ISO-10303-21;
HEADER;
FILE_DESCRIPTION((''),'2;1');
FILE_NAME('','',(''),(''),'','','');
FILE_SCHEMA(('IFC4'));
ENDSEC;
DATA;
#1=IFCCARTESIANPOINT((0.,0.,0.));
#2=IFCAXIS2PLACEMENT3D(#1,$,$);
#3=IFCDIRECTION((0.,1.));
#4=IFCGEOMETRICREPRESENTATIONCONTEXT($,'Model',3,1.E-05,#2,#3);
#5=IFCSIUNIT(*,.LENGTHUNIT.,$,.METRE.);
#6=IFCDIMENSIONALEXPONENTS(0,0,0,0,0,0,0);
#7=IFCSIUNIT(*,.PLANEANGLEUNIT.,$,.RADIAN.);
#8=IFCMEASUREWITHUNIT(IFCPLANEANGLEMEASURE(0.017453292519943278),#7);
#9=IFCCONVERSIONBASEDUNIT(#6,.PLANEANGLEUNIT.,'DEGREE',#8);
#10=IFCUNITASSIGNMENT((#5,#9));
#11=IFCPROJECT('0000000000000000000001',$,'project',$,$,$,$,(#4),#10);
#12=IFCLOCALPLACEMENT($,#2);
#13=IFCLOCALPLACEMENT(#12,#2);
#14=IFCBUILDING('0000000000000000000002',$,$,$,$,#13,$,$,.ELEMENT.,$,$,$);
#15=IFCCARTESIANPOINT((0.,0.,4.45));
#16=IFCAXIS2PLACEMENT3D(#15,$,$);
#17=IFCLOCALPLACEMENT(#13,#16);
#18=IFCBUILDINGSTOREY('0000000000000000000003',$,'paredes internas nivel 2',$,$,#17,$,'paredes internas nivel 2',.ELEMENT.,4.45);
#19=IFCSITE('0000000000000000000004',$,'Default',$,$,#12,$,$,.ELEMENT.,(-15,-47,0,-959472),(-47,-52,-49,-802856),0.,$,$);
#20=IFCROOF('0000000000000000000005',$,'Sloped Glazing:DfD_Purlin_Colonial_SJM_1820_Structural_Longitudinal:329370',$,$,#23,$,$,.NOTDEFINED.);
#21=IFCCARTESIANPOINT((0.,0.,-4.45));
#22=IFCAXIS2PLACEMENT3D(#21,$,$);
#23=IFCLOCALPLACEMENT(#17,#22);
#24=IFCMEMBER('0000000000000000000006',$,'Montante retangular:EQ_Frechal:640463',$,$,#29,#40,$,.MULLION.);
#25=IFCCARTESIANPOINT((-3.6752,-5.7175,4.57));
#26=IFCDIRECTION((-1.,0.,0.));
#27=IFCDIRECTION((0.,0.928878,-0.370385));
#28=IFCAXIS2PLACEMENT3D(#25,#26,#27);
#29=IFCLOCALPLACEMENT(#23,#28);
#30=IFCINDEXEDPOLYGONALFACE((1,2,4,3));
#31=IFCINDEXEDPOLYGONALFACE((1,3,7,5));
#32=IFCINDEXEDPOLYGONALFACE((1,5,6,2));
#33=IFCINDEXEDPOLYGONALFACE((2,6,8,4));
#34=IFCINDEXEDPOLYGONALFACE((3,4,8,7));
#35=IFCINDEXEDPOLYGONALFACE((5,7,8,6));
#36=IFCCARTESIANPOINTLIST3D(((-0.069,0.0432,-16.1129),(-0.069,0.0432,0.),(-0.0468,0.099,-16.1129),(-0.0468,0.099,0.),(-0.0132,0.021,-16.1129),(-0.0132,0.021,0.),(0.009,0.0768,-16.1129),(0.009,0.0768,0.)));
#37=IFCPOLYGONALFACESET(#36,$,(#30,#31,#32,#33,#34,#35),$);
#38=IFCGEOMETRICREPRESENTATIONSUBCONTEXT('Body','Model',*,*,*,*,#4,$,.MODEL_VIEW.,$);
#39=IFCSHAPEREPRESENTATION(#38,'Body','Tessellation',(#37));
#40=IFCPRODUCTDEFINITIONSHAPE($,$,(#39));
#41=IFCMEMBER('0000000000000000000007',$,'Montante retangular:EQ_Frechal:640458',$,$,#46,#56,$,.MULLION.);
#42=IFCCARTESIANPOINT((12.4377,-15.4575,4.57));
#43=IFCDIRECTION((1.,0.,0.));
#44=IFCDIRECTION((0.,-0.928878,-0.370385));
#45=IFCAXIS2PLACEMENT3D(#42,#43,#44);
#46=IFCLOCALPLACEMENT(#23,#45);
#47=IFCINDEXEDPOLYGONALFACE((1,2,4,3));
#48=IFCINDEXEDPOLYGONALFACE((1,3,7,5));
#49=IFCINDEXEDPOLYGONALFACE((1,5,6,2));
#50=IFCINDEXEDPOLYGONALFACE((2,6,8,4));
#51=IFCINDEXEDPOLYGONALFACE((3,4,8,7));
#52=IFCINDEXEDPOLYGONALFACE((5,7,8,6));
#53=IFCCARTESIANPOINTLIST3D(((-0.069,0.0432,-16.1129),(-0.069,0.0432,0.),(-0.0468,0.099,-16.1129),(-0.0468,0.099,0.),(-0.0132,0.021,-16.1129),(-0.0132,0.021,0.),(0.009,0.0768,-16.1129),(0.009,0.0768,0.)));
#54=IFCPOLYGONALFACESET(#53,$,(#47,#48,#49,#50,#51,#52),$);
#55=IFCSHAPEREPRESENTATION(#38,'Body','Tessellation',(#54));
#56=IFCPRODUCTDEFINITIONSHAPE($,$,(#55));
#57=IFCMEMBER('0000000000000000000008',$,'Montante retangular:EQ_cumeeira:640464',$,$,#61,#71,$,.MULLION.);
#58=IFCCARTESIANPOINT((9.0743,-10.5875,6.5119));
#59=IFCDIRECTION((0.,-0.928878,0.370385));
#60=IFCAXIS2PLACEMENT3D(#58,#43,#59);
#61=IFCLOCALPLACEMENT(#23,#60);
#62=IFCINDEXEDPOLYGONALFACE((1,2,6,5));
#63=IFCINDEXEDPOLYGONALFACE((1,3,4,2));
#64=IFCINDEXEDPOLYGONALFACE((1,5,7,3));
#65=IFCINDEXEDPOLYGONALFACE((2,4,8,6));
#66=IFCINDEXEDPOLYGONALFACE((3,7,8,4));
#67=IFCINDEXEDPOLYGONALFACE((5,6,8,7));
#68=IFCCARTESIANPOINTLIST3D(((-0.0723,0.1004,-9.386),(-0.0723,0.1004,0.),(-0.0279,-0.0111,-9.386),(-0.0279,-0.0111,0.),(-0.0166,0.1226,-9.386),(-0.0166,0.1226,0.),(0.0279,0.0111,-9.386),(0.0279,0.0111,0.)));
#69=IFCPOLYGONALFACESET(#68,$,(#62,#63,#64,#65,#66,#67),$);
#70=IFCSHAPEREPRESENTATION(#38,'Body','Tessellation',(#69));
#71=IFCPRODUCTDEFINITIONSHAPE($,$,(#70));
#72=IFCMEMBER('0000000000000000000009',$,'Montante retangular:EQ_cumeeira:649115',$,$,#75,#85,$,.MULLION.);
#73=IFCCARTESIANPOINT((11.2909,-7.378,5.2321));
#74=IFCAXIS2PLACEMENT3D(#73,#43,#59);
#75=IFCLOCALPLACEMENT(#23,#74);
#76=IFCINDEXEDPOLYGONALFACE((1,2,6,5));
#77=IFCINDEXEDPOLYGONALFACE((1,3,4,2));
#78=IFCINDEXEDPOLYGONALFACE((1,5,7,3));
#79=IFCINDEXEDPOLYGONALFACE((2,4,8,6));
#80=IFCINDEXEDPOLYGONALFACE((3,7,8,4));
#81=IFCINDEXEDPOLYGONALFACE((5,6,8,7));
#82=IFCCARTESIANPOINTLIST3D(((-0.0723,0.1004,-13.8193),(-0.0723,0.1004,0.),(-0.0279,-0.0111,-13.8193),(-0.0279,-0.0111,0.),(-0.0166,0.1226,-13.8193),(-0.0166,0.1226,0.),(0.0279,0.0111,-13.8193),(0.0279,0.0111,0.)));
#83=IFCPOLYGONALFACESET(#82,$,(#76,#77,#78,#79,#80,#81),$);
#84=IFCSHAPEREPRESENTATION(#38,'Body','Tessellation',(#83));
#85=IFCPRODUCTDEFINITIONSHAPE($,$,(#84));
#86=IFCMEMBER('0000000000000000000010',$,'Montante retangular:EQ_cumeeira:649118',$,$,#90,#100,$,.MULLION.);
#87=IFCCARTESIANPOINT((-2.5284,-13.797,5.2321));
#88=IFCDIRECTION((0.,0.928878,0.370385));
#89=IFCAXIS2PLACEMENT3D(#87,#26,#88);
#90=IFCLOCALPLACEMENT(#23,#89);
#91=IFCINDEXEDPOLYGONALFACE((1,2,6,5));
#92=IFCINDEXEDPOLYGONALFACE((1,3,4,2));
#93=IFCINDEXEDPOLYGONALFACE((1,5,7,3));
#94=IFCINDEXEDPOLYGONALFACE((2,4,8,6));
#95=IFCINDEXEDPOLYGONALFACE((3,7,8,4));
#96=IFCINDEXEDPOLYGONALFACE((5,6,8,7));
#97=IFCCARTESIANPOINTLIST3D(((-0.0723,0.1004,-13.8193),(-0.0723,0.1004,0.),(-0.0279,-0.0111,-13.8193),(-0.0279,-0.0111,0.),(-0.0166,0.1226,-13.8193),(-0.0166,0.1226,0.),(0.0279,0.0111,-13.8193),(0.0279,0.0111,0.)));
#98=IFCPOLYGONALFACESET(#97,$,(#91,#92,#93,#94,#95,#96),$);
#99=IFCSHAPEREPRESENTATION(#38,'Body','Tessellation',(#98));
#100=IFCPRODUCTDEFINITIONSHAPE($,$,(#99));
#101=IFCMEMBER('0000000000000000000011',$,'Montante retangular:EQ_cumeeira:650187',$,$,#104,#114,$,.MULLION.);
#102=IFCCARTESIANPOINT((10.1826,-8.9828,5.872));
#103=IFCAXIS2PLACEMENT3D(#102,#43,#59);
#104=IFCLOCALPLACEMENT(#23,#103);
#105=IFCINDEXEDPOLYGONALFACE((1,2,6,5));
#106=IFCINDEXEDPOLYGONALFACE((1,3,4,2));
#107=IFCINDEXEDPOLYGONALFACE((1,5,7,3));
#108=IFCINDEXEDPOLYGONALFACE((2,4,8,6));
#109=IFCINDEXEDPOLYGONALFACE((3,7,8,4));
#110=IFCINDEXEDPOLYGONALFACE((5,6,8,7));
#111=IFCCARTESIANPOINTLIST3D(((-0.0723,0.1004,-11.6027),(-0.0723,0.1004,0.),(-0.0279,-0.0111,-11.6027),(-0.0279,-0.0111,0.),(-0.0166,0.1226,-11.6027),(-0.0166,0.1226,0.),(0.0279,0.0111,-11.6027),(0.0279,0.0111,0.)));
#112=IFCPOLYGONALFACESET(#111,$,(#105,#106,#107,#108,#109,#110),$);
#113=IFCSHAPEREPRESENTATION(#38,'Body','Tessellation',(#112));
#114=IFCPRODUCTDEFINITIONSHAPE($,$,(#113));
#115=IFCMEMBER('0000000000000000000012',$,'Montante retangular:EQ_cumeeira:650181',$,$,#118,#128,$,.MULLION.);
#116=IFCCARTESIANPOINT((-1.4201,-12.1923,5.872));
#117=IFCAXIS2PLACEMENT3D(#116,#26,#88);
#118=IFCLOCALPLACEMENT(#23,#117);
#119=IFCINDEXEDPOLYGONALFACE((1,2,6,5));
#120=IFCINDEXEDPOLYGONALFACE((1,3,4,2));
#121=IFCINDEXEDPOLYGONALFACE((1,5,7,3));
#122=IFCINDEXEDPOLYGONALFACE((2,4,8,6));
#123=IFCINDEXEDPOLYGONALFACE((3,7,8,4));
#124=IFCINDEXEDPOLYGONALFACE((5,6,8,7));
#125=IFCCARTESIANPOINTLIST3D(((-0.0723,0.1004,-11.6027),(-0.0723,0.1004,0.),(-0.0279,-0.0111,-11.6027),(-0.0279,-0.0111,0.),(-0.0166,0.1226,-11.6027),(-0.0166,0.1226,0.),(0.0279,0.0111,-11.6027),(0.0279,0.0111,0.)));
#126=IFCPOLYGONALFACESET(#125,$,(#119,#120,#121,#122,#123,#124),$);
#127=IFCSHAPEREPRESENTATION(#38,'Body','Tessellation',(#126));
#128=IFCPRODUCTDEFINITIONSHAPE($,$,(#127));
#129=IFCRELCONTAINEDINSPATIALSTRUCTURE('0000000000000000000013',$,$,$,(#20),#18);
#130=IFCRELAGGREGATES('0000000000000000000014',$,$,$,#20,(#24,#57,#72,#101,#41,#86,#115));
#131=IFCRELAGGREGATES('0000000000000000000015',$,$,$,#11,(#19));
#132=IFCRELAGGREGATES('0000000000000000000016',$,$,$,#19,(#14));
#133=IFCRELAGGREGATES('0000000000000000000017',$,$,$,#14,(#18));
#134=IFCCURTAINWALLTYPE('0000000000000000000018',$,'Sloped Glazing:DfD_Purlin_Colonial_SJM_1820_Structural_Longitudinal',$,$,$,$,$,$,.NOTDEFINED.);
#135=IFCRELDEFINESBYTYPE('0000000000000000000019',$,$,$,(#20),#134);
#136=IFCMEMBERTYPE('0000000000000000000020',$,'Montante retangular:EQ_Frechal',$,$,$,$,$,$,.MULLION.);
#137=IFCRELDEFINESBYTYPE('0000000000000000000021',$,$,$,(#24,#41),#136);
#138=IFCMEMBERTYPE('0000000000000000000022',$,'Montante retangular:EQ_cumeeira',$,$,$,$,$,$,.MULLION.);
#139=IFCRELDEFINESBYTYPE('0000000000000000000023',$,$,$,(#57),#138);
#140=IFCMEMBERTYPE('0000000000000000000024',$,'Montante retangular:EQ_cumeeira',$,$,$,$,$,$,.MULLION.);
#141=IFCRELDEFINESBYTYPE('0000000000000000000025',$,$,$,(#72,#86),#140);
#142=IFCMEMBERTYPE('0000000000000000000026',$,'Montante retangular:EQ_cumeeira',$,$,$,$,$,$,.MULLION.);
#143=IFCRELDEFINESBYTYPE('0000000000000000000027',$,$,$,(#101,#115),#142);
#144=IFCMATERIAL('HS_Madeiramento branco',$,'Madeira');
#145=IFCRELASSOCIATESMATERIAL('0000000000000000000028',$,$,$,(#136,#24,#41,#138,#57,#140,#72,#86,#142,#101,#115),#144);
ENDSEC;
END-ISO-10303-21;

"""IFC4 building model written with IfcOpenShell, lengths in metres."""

from ifc_helpers import new_model, entity, si_unit, converted_unit, direction, frame, origin, place, context, subcontext, project, spatial, indexed_curve, outline, extrude, source, transform, mapped, material, type_object, type_shapes, element, aggregate, save


model = new_model("IFC4")

# Units and contexts
model_context = context("Model", 3, precision=1e-05, world=origin(), true_north=direction((0.0, 1.0)))
body_context = subcontext(model_context, "Body", "Model", "MODEL_VIEW")
ifc_project = project(units=[si_unit("LENGTHUNIT", "METRE"), converted_unit("PLANEANGLEUNIT", "DEGREE", entity("IfcPlaneAngleMeasure", 0.017453292519943278), si_unit("PLANEANGLEUNIT", "RADIAN"), dimensions=[0, 0, 0, 0, 0, 0, 0])], contexts=[model_context])

# Site, building, storey
site_placement = place(None, origin())
site = spatial("IfcSite", under=ifc_project, at=site_placement, Name="Default", CompositionType="ELEMENT", RefLatitude=(-15, -47, 0, -959472), RefLongitude=(-47, -52, -49, -802856), RefElevation=0.0)
building_placement = place(site_placement, origin())
building = spatial("IfcBuilding", under=site, at=building_placement, CompositionType="ELEMENT")
storey_placement = place(building_placement, frame((0.0, 0.0, 4.45)))
storey = spatial("IfcBuildingStorey", under=building, at=storey_placement, Name="paredes internas nivel 2", LongName="paredes internas nivel 2", CompositionType="ELEMENT", Elevation=4.45)

# Roof, members
curtain_wall_type = type_object("IfcCurtainWallType", Name="Sloped Glazing:DfD_Purlin_Colonial_SJM_1820_Structural_Longitudinal", PredefinedType="NOTDEFINED")
roof_placement = place(storey_placement, frame((0.0, 0.0, -4.45)))
roof = element("IfcRoof", 1, at=roof_placement, inside=storey, type_object=curtain_wall_type, Name="Sloped Glazing:DfD_Purlin_Colonial_SJM_1820_Structural_Longitudinal:329370", PredefinedType="NOTDEFINED")
ifc_material = material(Name="HS_Madeiramento branco", Category="Madeira")
member_type_1 = type_object("IfcMemberType", Name="Montante retangular:EQ_Frechal", PredefinedType="MULLION", material=ifc_material)
shared_shape_1 = source(origin(), body_context, "Body", "SweptSolid", [
    extrude(outline(indexed_curve([(-0.03, -0.03), (0.03, -0.03), (0.03, 0.03), (-0.03, 0.03), (-0.03, -0.03)], self_intersect=False)), frame((-0.03, 0.06, -16.1129), z_axis=(0.0, 0.0, 1.0), x_axis=(0.928878, -0.370385, 0.0)), (0.0, 0.0, 1.0), 16.1129),
])
type_shapes(member_type_1, [shared_shape_1])
member_1_placement = place(roof_placement, frame((-3.6752, -5.7175, 4.57), z_axis=(-1.0, 0.0, 0.0), x_axis=(0.0, 0.928878, -0.370385)))
member_1 = element("IfcMember", 2, at=member_1_placement, type_object=member_type_1, material=ifc_material, Name="Montante retangular:EQ_Frechal:640463", PredefinedType="MULLION", context=body_context, shape_type="MappedRepresentation", body=[
    mapped(shared_shape_1, transform((0.0, 0.0, 0.0), scale=1.0)),
])
member_2_placement = place(roof_placement, frame((12.4377, -15.4575, 4.57), z_axis=(1.0, 0.0, 0.0), x_axis=(0.0, -0.928878, -0.370385)))
member_2 = element("IfcMember", 3, at=member_2_placement, type_object=member_type_1, material=ifc_material, Name="Montante retangular:EQ_Frechal:640458", PredefinedType="MULLION", context=body_context, shape_type="MappedRepresentation", body=[
    mapped(shared_shape_1, transform((0.0, 0.0, 0.0), scale=1.0)),
])
member_type_2 = type_object("IfcMemberType", Name="Montante retangular:EQ_cumeeira", PredefinedType="MULLION", material=ifc_material)
shared_shape_2 = source(origin(), body_context, "Body", "SweptSolid", [
    extrude(outline(indexed_curve([(-0.06, -0.03), (0.06, -0.03), (0.06, 0.03), (-0.06, 0.03), (-0.06, -0.03)], self_intersect=False)), frame((-0.0222, 0.0557, -9.386), z_axis=(0.0, 0.0, 1.0), x_axis=(-0.370385, 0.928878, 0.0)), (0.0, 0.0, 1.0), 9.386),
])
type_shapes(member_type_2, [shared_shape_2])
member_3_placement = place(roof_placement, frame((9.0743, -10.5875, 6.5119), z_axis=(1.0, 0.0, 0.0), x_axis=(0.0, -0.928878, 0.370385)))
member_3 = element("IfcMember", 4, at=member_3_placement, type_object=member_type_2, material=ifc_material, Name="Montante retangular:EQ_cumeeira:640464", PredefinedType="MULLION", context=body_context, shape_type="MappedRepresentation", body=[
    mapped(shared_shape_2, transform((0.0, 0.0, 0.0), scale=1.0)),
])
member_type_3 = type_object("IfcMemberType", Name="Montante retangular:EQ_cumeeira", PredefinedType="MULLION", material=ifc_material)
shared_shape_3 = source(origin(), body_context, "Body", "SweptSolid", [
    extrude(outline(indexed_curve([(-0.06, -0.03), (0.06, -0.03), (0.06, 0.03), (-0.06, 0.03), (-0.06, -0.03)], self_intersect=False)), frame((-0.0222, 0.0557, -13.8193), z_axis=(0.0, 0.0, 1.0), x_axis=(-0.370385, 0.928878, 0.0)), (0.0, 0.0, 1.0), 13.8193),
])
type_shapes(member_type_3, [shared_shape_3])
member_4_placement = place(roof_placement, frame((11.2909, -7.378, 5.2321), z_axis=(1.0, 0.0, 0.0), x_axis=(0.0, -0.928878, 0.370385)))
member_4 = element("IfcMember", 5, at=member_4_placement, type_object=member_type_3, material=ifc_material, Name="Montante retangular:EQ_cumeeira:649115", PredefinedType="MULLION", context=body_context, shape_type="MappedRepresentation", body=[
    mapped(shared_shape_3, transform((0.0, 0.0, 0.0), scale=1.0)),
])
member_5_placement = place(roof_placement, frame((-2.5284, -13.797, 5.2321), z_axis=(-1.0, 0.0, 0.0), x_axis=(0.0, 0.928878, 0.370385)))
member_5 = element("IfcMember", 6, at=member_5_placement, type_object=member_type_3, material=ifc_material, Name="Montante retangular:EQ_cumeeira:649118", PredefinedType="MULLION", context=body_context, shape_type="MappedRepresentation", body=[
    mapped(shared_shape_3, transform((0.0, 0.0, 0.0), scale=1.0)),
])
member_type_4 = type_object("IfcMemberType", Name="Montante retangular:EQ_cumeeira", PredefinedType="MULLION", material=ifc_material)
shared_shape_4 = source(origin(), body_context, "Body", "SweptSolid", [
    extrude(outline(indexed_curve([(-0.06, -0.03), (0.06, -0.03), (0.06, 0.03), (-0.06, 0.03), (-0.06, -0.03)], self_intersect=False)), frame((-0.0222, 0.0557, -11.6027), z_axis=(0.0, 0.0, 1.0), x_axis=(-0.370385, 0.928878, 0.0)), (0.0, 0.0, 1.0), 11.6027),
])
type_shapes(member_type_4, [shared_shape_4])
member_6_placement = place(roof_placement, frame((10.1826, -8.9828, 5.872), z_axis=(1.0, 0.0, 0.0), x_axis=(0.0, -0.928878, 0.370385)))
member_6 = element("IfcMember", 7, at=member_6_placement, type_object=member_type_4, material=ifc_material, Name="Montante retangular:EQ_cumeeira:650187", PredefinedType="MULLION", context=body_context, shape_type="MappedRepresentation", body=[
    mapped(shared_shape_4, transform((0.0, 0.0, 0.0), scale=1.0)),
])
member_7_placement = place(roof_placement, frame((-1.4201, -12.1923, 5.872), z_axis=(-1.0, 0.0, 0.0), x_axis=(0.0, 0.928878, 0.370385)))
member_7 = element("IfcMember", 8, at=member_7_placement, type_object=member_type_4, material=ifc_material, Name="Montante retangular:EQ_cumeeira:650181", PredefinedType="MULLION", context=body_context, shape_type="MappedRepresentation", body=[
    mapped(shared_shape_4, transform((0.0, 0.0, 0.0), scale=1.0)),
])
aggregate(roof, [member_1, member_3, member_4, member_6, member_2, member_5, member_7])

save(model, "model.ifc")
